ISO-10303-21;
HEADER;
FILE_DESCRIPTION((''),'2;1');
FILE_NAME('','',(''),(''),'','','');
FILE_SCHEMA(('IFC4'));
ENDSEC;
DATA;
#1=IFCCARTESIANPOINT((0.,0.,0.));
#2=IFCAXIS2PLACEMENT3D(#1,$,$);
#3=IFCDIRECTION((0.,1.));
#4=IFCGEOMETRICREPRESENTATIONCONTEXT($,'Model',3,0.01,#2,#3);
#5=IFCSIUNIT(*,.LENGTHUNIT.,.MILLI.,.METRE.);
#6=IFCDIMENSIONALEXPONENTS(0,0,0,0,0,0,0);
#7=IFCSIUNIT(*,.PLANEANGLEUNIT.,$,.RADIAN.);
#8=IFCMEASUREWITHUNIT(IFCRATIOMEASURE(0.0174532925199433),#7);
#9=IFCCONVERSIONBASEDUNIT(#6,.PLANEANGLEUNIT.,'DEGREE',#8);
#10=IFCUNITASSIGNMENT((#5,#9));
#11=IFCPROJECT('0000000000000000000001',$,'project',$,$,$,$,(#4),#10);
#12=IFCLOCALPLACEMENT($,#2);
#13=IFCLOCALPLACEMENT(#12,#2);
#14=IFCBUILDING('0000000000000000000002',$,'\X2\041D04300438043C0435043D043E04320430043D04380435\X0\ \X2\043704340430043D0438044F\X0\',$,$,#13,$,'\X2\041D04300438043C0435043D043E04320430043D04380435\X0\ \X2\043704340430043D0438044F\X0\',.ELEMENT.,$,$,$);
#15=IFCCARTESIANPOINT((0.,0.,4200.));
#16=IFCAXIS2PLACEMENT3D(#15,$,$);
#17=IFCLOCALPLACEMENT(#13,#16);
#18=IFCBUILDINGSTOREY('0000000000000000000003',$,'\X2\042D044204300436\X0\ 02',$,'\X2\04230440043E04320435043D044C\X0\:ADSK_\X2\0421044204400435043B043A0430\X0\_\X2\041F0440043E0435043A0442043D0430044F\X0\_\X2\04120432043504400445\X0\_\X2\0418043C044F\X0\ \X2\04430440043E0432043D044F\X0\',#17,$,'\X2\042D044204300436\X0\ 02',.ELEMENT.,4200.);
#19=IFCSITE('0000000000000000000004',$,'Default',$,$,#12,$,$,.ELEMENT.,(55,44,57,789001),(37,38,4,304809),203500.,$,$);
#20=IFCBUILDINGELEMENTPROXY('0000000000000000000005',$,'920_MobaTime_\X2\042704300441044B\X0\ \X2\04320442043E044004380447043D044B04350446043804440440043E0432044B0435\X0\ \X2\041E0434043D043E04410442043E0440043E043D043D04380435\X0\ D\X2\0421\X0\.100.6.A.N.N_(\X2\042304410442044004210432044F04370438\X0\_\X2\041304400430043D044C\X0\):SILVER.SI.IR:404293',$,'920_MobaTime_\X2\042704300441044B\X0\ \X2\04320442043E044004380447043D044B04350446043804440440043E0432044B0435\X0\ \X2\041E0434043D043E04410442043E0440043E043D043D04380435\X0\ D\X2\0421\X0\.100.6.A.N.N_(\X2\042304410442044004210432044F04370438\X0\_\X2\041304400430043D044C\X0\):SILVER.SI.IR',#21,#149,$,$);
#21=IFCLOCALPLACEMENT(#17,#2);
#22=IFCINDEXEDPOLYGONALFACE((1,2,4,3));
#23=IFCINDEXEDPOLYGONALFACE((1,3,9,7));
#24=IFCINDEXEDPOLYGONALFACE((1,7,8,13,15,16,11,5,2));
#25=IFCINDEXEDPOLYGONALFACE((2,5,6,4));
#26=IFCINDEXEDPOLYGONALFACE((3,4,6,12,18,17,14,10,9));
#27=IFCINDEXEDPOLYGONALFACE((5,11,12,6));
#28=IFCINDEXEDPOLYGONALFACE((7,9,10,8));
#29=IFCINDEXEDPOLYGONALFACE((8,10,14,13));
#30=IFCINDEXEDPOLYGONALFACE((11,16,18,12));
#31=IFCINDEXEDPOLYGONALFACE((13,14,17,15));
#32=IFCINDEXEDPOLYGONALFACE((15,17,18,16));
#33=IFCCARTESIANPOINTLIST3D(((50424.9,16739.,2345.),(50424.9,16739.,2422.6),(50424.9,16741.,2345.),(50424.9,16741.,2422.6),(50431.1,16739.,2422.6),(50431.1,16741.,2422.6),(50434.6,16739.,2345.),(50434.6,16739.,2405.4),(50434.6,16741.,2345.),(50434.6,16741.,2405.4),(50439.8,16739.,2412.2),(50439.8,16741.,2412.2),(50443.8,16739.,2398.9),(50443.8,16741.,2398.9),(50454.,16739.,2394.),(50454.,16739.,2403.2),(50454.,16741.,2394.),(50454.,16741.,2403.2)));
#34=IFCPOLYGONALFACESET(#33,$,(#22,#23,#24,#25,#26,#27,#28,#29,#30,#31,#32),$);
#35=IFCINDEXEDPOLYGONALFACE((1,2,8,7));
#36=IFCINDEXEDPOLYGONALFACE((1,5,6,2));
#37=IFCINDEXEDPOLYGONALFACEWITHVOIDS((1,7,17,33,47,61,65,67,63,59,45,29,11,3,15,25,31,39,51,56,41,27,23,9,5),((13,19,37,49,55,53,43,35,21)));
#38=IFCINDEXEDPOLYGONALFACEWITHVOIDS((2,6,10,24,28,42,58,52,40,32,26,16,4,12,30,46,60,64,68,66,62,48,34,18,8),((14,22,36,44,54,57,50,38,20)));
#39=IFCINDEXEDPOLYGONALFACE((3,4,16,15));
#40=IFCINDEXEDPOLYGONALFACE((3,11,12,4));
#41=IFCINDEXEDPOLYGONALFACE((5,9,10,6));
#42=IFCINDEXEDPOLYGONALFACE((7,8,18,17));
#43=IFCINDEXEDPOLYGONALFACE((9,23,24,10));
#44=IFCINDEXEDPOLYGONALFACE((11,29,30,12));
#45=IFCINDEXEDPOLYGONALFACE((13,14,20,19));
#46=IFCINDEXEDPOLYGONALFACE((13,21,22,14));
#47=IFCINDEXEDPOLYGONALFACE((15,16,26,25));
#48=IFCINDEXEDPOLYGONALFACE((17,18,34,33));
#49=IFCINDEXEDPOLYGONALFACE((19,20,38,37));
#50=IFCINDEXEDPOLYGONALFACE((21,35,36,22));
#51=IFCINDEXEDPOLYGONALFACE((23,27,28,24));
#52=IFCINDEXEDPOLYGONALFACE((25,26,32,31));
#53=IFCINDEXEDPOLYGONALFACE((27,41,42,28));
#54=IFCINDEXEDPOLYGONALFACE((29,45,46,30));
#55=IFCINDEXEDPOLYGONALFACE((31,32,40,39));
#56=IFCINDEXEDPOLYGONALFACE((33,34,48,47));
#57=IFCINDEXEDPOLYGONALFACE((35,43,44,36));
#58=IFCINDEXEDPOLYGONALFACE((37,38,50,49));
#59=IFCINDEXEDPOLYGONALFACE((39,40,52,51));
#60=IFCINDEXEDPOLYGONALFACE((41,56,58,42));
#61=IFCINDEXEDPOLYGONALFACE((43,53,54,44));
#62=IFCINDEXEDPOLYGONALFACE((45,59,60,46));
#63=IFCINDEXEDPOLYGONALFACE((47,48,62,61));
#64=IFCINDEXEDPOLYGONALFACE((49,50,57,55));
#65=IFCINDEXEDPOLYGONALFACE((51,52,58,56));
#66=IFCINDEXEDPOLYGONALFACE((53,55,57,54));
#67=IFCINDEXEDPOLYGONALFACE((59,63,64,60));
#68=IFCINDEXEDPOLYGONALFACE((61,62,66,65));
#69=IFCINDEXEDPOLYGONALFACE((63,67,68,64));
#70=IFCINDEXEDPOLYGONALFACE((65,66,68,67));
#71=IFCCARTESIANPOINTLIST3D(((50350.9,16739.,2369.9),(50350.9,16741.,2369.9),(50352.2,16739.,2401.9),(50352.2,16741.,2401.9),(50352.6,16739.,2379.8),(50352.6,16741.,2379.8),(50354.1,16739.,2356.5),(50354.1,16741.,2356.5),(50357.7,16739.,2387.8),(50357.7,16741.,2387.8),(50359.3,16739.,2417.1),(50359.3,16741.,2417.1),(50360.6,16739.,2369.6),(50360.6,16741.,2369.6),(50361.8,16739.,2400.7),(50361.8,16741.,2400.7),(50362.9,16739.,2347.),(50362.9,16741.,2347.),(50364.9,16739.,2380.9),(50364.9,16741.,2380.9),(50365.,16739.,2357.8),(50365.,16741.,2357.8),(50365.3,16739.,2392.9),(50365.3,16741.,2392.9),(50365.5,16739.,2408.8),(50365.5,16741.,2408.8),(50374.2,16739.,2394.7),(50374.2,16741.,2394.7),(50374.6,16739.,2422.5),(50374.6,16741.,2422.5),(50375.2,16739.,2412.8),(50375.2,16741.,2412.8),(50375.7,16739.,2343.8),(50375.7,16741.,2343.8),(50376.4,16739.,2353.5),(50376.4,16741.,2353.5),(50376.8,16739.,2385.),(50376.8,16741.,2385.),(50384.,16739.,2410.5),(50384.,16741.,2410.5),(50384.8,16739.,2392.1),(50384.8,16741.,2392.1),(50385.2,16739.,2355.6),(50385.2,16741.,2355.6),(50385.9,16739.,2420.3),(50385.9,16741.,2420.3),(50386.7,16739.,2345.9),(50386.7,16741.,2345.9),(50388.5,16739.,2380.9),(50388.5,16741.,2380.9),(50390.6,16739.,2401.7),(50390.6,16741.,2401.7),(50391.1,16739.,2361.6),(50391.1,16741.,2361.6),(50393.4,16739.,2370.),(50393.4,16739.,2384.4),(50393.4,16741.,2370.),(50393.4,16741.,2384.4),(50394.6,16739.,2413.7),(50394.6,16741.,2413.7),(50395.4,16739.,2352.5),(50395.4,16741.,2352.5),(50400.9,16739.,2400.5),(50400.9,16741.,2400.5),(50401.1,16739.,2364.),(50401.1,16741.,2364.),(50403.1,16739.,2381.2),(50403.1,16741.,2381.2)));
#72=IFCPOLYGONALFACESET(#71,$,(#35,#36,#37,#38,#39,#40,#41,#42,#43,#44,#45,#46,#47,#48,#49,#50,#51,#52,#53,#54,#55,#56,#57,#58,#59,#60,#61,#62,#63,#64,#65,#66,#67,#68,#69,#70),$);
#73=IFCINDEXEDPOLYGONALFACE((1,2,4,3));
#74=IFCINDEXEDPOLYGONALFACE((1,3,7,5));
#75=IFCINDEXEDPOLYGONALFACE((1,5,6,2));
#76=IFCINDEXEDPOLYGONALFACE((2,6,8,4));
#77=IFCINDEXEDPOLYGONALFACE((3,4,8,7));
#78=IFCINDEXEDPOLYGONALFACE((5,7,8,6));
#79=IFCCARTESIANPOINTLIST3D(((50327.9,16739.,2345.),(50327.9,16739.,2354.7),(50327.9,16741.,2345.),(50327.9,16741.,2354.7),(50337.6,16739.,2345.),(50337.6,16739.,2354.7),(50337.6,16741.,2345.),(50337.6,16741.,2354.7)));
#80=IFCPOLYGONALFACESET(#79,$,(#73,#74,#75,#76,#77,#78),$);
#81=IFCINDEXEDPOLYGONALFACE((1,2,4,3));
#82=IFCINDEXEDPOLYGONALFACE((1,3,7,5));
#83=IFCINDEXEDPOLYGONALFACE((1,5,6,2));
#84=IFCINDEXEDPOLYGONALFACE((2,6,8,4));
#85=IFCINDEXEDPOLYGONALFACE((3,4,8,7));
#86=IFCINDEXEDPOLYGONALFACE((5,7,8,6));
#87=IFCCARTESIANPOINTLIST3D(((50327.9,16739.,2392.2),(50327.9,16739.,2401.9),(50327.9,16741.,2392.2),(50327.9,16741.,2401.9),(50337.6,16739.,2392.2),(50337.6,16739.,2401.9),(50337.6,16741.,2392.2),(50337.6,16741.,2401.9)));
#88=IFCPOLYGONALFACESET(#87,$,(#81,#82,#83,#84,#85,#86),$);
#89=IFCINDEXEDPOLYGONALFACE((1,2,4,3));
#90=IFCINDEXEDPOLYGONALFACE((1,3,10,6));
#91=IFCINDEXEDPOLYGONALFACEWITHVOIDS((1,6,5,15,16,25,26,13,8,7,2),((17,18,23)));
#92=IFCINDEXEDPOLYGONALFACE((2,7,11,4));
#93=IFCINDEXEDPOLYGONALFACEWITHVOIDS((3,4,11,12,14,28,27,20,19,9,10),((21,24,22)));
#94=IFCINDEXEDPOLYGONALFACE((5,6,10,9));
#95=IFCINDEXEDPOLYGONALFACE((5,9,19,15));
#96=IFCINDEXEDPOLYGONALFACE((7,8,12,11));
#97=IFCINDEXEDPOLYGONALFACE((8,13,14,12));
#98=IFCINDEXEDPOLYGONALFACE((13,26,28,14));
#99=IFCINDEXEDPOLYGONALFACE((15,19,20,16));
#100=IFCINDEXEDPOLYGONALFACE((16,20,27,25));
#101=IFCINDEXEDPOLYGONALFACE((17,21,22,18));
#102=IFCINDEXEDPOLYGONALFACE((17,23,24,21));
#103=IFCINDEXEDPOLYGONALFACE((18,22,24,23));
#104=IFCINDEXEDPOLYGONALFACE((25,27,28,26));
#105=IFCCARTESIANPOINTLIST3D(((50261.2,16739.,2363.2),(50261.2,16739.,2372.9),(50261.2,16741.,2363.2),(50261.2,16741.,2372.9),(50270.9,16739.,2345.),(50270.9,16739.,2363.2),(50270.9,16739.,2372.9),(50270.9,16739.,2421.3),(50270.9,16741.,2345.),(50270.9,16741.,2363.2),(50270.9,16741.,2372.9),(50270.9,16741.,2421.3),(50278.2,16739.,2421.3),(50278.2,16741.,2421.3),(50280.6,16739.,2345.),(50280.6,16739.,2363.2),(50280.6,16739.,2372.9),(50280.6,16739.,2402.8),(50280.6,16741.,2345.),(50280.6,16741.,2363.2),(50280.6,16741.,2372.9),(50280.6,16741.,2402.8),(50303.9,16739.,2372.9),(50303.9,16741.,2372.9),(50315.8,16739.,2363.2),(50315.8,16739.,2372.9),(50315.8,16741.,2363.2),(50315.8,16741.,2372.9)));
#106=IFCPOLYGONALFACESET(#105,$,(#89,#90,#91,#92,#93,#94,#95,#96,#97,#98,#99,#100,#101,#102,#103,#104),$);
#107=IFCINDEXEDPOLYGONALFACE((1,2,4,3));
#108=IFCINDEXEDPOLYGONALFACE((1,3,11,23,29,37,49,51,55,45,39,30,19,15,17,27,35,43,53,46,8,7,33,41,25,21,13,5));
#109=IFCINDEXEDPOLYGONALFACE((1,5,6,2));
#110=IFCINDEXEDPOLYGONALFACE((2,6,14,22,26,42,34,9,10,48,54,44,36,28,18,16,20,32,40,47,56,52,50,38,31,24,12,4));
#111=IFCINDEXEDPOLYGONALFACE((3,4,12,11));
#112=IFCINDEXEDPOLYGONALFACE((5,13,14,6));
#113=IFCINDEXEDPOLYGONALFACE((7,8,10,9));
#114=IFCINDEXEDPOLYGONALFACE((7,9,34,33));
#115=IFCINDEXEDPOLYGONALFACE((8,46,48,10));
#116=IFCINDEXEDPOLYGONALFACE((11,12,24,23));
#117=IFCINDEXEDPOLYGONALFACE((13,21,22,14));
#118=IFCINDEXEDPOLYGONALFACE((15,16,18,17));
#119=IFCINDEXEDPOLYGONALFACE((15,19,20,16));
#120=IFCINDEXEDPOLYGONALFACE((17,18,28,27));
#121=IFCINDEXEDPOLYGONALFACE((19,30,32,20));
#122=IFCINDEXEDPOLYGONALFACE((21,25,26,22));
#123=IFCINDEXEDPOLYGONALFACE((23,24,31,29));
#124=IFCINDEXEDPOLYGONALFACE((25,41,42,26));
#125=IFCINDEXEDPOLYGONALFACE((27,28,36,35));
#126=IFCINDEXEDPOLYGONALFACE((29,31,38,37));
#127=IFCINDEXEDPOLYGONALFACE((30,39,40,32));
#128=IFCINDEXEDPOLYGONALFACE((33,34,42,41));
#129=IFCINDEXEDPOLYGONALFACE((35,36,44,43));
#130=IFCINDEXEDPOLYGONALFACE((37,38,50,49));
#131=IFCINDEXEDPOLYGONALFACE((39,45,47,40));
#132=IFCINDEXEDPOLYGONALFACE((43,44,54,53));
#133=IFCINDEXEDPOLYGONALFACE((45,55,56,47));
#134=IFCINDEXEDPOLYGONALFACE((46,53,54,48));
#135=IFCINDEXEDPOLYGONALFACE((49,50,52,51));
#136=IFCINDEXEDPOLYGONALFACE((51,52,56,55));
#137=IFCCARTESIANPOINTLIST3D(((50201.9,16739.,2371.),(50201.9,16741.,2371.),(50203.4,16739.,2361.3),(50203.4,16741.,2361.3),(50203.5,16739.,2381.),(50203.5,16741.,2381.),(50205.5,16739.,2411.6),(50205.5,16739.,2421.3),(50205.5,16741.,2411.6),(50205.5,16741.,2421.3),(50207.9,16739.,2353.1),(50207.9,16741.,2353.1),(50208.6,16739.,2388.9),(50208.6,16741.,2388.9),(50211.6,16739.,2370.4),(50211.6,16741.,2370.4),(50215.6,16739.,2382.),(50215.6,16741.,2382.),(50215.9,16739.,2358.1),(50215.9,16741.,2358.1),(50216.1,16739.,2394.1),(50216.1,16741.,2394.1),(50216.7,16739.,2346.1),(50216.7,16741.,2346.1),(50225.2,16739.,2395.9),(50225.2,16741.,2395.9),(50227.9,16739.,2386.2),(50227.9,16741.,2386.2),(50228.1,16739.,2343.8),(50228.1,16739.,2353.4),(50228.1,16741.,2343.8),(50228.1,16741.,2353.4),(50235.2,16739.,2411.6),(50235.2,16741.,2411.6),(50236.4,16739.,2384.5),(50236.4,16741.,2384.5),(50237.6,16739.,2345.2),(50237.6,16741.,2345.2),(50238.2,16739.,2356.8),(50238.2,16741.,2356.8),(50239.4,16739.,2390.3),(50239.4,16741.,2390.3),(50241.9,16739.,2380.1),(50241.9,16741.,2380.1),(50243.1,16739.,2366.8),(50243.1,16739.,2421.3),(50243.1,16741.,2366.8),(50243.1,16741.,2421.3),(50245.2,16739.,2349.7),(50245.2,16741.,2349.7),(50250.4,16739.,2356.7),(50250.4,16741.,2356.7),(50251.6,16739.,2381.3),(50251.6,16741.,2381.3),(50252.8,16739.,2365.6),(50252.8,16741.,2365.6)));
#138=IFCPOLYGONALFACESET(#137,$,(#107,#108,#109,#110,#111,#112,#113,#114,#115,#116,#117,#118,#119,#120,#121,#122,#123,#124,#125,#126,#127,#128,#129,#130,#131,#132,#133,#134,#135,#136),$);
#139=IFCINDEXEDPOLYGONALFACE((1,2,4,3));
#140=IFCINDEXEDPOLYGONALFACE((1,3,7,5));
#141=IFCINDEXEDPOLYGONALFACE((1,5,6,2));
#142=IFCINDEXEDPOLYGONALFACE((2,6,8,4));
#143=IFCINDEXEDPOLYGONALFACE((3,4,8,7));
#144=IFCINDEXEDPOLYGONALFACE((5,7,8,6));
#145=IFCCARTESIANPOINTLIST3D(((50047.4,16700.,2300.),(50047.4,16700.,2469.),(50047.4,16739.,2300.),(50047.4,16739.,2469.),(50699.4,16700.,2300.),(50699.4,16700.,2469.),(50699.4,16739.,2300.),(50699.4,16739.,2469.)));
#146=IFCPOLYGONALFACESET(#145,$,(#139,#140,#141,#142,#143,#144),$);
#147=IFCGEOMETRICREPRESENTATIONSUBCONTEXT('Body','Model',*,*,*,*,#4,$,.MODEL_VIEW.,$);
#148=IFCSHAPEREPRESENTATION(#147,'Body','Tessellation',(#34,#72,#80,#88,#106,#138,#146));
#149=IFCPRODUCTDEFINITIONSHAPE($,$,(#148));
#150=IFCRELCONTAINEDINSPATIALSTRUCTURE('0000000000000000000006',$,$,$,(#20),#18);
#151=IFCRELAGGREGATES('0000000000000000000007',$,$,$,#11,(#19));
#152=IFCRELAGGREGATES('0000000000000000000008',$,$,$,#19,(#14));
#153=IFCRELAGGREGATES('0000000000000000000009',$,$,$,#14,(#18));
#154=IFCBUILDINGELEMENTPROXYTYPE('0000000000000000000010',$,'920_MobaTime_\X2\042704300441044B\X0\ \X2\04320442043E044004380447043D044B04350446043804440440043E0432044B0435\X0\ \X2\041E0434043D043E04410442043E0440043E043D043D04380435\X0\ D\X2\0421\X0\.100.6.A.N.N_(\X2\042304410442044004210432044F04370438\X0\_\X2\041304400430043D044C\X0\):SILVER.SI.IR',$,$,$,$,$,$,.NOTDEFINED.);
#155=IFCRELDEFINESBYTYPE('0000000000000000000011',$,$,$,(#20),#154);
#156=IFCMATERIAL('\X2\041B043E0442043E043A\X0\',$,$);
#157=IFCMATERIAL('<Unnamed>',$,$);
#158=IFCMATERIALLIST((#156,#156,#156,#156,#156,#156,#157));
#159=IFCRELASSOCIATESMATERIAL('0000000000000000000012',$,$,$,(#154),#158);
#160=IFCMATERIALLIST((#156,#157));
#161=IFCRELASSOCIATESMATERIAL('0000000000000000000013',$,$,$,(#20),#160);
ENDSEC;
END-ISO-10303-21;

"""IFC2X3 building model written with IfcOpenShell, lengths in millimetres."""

from ifc_helpers import new_model, entity, si_unit, converted_unit, direction, frame, origin, origin_2d_with_axis, place, context, subcontext, project, spatial, polyline, rectangle, outline, extrude, source, transform, mapped, material, material_list, type_object, type_shapes, element, save


model = new_model("IFC2X3")

# Units and contexts
model_context = context("Model", 3, precision=0.01, world=origin(), true_north=direction((0.0, 1.0)))
body_context = subcontext(model_context, "Body", "Model", "MODEL_VIEW")
ifc_project = project(units=[si_unit("LENGTHUNIT", "METRE", prefix="MILLI"), converted_unit("PLANEANGLEUNIT", "DEGREE", entity("IfcRatioMeasure", 0.0174532925199433), si_unit("PLANEANGLEUNIT", "RADIAN"), dimensions=[0, 0, 0, 0, 0, 0, 0])], contexts=[model_context])

# Site, building, storey
site_placement = place(None, origin())
site = spatial("IfcSite", under=ifc_project, at=site_placement, Name="Default", CompositionType="ELEMENT", RefLatitude=(55, 44, 57, 789001), RefLongitude=(37, 38, 4, 304809), RefElevation=203500.0)
building_placement = place(site_placement, origin())
building = spatial("IfcBuilding", under=site, at=building_placement, Name="Наименование здания", LongName="Наименование здания", CompositionType="ELEMENT")
storey_placement = place(building_placement, frame((0.0, 0.0, 4200.0)))
storey = spatial("IfcBuildingStorey", under=building, at=storey_placement, Name="Этаж 02", ObjectType="Уровень:ADSK_Стрелка_Проектная_Вверх_Имя уровня", LongName="Этаж 02", CompositionType="ELEMENT", Elevation=4200.0)

# Building element proxy
ifc_material_1 = material(Name="Лоток")
ifc_material_2 = material(Name="<Unnamed>")
ifc_material_list_1 = material_list([ifc_material_1, ifc_material_2])
ifc_material_list_2 = material_list([ifc_material_1, ifc_material_1, ifc_material_1, ifc_material_1, ifc_material_1, ifc_material_1, ifc_material_2])
building_element_proxy_type_1 = type_object("IfcBuildingElementProxyType", Name="920_MobaTime_Часы вторичныецифровые Односторонние DС.100.6.A.N.N_(УстрСвязи_Грань):SILVER.SI.IR", PredefinedType="NOTDEFINED", material=ifc_material_list_2)
shared_shape_1 = source(origin(), body_context, "Body", "SweptSolid", [
    extrude(outline(polyline([(-49.3, -13.1), (28.2, -13.1), (28.2, -6.8), (17.9, 1.8), (8.8, 16.0), (-0.3, 16.0), (4.6, 5.8), (11.1, -3.4), (-49.3, -3.4), (-49.3, -13.1)])), frame((-64.6, 9.8, 39.0), z_axis=(0.0, 0.0, 1.0), x_axis=(0.0, 1.0, 0.0)), (0.0, 0.0, 1.0), 2.0),
    extrude(outline(polyline([(2.2, -27.6), (19.0, -27.6), (30.5, -16.1), (33.3, -4.9), (31.0, 5.8), (21.8, 17.2), (5.2, 27.3), (-11.1, 33.0), (-24.0, 32.7), (-33.6, 27.6), (-40.3, 18.6), (-42.8, 5.7), (-38.0, -6.3), (-27.2, -14.9), (-17.5, -17.7), (-8.2, -16.4), (-0.3, -11.9), (5.1, -4.5), (7.3, 6.2), (4.0, 17.2), (18.4, 7.3), (23.6, -2.4), (22.0, -11.4), (14.2, -18.4), (5.3, -18.3), (2.2, -27.6)]), holes=[polyline([(-9.0, 23.3), (-1.3, 14.3), (-2.5, 2.0), (-11.4, -7.0), (-23.4, -6.0), (-32.2, 2.9), (-31.2, 15.1), (-25.6, 22.1), (-17.5, 24.9), (-9.0, 23.3)])]), frame((-2.7, 3.6, 39.0), z_axis=(0.0, 0.0, 1.0), x_axis=(-0.427649, 0.903945, 0.0)), (0.0, 0.0, 1.0), 2.0),
    extrude(rectangle(XDim=9.7, YDim=9.7, at=origin_2d_with_axis()), frame((40.6, -34.7, 39.0)), (0.0, 0.0, 1.0), 2.0),
    extrude(rectangle(XDim=9.7, YDim=9.7, at=origin_2d_with_axis()), frame((40.6, 12.6, 39.0)), (0.0, 0.0, 1.0), 2.0),
    extrude(outline(polyline([(-0.9, -28.1), (8.8, -28.1), (8.8, -9.9), (18.5, -9.9), (18.5, -0.2), (8.8, -0.2), (8.8, 48.3), (1.5, 48.3), (-36.0, -0.2), (-36.0, -9.9), (-0.9, -9.9), (-0.9, -28.1)]), holes=[polyline([(-0.9, -0.2), (-24.1, -0.2), (-0.9, 29.7), (-0.9, -0.2)])]), frame((93.6, -11.4, 39.0)), (0.0, 0.0, 1.0), 2.0),
    extrude(outline(polyline([(3.3, -28.3), (12.5, -28.3), (20.5, -25.0), (26.8, -18.9), (30.7, -10.0), (31.4, 1.6), (26.9, 11.8), (20.1, 18.4), (11.1, 22.3), (1.0, 23.3), (-7.9, 20.4), (-14.9, 14.5), (-18.9, 6.2), (-17.1, -9.0), (-36.7, 0.5), (-29.1, 29.2), (-38.5, 31.7), (-48.1, -4.6), (-11.6, -23.1), (-8.0, -14.0), (-10.8, -7.6), (-10.2, 1.1), (-3.0, 11.8), (9.2, 12.8), (20.0, 5.5), (21.4, -7.5), (15.5, -16.4), (4.6, -18.6), (3.3, -28.3)])), frame((147.1, -8.5, 39.0), z_axis=(0.0, 0.0, 1.0), x_axis=(0.256974, -0.966418, 0.0)), (0.0, 0.0, 1.0), 2.0),
    extrude(rectangle(XDim=652.0, YDim=169.0, at=origin_2d_with_axis()), frame((0.0, 0.0, 0.0), z_axis=(0.0, 0.0, 1.0), x_axis=(-1.0, 0.0, 0.0)), (0.0, 0.0, 1.0), 39.0),
])
type_shapes(building_element_proxy_type_1, [shared_shape_1])
for number, where, z_axis, x_axis, name in (
    (1, (50373.4, 16700.0, 2384.5), (0.0, 1.0, 0.0), (-1.0, 0.0, 0.0), "920_MobaTime_Часы вторичныецифровые Односторонние DС.100.6.A.N.N_(УстрСвязи_Грань):SILVER.SI.IR:404293"),
):
    element("IfcBuildingElementProxy", number, at=place(storey_placement, frame(where, z_axis=z_axis, x_axis=x_axis)), inside=storey, type_object=building_element_proxy_type_1, material=ifc_material_list_1, Name=name, ObjectType="920_MobaTime_Часы вторичныецифровые Односторонние DС.100.6.A.N.N_(УстрСвязи_Грань):SILVER.SI.IR", context=body_context, shape_type="MappedRepresentation", body=[
        mapped(shared_shape_1, transform((0.0, 0.0, 0.0), scale=1.0)),
    ])

save(model, "model.ifc")
